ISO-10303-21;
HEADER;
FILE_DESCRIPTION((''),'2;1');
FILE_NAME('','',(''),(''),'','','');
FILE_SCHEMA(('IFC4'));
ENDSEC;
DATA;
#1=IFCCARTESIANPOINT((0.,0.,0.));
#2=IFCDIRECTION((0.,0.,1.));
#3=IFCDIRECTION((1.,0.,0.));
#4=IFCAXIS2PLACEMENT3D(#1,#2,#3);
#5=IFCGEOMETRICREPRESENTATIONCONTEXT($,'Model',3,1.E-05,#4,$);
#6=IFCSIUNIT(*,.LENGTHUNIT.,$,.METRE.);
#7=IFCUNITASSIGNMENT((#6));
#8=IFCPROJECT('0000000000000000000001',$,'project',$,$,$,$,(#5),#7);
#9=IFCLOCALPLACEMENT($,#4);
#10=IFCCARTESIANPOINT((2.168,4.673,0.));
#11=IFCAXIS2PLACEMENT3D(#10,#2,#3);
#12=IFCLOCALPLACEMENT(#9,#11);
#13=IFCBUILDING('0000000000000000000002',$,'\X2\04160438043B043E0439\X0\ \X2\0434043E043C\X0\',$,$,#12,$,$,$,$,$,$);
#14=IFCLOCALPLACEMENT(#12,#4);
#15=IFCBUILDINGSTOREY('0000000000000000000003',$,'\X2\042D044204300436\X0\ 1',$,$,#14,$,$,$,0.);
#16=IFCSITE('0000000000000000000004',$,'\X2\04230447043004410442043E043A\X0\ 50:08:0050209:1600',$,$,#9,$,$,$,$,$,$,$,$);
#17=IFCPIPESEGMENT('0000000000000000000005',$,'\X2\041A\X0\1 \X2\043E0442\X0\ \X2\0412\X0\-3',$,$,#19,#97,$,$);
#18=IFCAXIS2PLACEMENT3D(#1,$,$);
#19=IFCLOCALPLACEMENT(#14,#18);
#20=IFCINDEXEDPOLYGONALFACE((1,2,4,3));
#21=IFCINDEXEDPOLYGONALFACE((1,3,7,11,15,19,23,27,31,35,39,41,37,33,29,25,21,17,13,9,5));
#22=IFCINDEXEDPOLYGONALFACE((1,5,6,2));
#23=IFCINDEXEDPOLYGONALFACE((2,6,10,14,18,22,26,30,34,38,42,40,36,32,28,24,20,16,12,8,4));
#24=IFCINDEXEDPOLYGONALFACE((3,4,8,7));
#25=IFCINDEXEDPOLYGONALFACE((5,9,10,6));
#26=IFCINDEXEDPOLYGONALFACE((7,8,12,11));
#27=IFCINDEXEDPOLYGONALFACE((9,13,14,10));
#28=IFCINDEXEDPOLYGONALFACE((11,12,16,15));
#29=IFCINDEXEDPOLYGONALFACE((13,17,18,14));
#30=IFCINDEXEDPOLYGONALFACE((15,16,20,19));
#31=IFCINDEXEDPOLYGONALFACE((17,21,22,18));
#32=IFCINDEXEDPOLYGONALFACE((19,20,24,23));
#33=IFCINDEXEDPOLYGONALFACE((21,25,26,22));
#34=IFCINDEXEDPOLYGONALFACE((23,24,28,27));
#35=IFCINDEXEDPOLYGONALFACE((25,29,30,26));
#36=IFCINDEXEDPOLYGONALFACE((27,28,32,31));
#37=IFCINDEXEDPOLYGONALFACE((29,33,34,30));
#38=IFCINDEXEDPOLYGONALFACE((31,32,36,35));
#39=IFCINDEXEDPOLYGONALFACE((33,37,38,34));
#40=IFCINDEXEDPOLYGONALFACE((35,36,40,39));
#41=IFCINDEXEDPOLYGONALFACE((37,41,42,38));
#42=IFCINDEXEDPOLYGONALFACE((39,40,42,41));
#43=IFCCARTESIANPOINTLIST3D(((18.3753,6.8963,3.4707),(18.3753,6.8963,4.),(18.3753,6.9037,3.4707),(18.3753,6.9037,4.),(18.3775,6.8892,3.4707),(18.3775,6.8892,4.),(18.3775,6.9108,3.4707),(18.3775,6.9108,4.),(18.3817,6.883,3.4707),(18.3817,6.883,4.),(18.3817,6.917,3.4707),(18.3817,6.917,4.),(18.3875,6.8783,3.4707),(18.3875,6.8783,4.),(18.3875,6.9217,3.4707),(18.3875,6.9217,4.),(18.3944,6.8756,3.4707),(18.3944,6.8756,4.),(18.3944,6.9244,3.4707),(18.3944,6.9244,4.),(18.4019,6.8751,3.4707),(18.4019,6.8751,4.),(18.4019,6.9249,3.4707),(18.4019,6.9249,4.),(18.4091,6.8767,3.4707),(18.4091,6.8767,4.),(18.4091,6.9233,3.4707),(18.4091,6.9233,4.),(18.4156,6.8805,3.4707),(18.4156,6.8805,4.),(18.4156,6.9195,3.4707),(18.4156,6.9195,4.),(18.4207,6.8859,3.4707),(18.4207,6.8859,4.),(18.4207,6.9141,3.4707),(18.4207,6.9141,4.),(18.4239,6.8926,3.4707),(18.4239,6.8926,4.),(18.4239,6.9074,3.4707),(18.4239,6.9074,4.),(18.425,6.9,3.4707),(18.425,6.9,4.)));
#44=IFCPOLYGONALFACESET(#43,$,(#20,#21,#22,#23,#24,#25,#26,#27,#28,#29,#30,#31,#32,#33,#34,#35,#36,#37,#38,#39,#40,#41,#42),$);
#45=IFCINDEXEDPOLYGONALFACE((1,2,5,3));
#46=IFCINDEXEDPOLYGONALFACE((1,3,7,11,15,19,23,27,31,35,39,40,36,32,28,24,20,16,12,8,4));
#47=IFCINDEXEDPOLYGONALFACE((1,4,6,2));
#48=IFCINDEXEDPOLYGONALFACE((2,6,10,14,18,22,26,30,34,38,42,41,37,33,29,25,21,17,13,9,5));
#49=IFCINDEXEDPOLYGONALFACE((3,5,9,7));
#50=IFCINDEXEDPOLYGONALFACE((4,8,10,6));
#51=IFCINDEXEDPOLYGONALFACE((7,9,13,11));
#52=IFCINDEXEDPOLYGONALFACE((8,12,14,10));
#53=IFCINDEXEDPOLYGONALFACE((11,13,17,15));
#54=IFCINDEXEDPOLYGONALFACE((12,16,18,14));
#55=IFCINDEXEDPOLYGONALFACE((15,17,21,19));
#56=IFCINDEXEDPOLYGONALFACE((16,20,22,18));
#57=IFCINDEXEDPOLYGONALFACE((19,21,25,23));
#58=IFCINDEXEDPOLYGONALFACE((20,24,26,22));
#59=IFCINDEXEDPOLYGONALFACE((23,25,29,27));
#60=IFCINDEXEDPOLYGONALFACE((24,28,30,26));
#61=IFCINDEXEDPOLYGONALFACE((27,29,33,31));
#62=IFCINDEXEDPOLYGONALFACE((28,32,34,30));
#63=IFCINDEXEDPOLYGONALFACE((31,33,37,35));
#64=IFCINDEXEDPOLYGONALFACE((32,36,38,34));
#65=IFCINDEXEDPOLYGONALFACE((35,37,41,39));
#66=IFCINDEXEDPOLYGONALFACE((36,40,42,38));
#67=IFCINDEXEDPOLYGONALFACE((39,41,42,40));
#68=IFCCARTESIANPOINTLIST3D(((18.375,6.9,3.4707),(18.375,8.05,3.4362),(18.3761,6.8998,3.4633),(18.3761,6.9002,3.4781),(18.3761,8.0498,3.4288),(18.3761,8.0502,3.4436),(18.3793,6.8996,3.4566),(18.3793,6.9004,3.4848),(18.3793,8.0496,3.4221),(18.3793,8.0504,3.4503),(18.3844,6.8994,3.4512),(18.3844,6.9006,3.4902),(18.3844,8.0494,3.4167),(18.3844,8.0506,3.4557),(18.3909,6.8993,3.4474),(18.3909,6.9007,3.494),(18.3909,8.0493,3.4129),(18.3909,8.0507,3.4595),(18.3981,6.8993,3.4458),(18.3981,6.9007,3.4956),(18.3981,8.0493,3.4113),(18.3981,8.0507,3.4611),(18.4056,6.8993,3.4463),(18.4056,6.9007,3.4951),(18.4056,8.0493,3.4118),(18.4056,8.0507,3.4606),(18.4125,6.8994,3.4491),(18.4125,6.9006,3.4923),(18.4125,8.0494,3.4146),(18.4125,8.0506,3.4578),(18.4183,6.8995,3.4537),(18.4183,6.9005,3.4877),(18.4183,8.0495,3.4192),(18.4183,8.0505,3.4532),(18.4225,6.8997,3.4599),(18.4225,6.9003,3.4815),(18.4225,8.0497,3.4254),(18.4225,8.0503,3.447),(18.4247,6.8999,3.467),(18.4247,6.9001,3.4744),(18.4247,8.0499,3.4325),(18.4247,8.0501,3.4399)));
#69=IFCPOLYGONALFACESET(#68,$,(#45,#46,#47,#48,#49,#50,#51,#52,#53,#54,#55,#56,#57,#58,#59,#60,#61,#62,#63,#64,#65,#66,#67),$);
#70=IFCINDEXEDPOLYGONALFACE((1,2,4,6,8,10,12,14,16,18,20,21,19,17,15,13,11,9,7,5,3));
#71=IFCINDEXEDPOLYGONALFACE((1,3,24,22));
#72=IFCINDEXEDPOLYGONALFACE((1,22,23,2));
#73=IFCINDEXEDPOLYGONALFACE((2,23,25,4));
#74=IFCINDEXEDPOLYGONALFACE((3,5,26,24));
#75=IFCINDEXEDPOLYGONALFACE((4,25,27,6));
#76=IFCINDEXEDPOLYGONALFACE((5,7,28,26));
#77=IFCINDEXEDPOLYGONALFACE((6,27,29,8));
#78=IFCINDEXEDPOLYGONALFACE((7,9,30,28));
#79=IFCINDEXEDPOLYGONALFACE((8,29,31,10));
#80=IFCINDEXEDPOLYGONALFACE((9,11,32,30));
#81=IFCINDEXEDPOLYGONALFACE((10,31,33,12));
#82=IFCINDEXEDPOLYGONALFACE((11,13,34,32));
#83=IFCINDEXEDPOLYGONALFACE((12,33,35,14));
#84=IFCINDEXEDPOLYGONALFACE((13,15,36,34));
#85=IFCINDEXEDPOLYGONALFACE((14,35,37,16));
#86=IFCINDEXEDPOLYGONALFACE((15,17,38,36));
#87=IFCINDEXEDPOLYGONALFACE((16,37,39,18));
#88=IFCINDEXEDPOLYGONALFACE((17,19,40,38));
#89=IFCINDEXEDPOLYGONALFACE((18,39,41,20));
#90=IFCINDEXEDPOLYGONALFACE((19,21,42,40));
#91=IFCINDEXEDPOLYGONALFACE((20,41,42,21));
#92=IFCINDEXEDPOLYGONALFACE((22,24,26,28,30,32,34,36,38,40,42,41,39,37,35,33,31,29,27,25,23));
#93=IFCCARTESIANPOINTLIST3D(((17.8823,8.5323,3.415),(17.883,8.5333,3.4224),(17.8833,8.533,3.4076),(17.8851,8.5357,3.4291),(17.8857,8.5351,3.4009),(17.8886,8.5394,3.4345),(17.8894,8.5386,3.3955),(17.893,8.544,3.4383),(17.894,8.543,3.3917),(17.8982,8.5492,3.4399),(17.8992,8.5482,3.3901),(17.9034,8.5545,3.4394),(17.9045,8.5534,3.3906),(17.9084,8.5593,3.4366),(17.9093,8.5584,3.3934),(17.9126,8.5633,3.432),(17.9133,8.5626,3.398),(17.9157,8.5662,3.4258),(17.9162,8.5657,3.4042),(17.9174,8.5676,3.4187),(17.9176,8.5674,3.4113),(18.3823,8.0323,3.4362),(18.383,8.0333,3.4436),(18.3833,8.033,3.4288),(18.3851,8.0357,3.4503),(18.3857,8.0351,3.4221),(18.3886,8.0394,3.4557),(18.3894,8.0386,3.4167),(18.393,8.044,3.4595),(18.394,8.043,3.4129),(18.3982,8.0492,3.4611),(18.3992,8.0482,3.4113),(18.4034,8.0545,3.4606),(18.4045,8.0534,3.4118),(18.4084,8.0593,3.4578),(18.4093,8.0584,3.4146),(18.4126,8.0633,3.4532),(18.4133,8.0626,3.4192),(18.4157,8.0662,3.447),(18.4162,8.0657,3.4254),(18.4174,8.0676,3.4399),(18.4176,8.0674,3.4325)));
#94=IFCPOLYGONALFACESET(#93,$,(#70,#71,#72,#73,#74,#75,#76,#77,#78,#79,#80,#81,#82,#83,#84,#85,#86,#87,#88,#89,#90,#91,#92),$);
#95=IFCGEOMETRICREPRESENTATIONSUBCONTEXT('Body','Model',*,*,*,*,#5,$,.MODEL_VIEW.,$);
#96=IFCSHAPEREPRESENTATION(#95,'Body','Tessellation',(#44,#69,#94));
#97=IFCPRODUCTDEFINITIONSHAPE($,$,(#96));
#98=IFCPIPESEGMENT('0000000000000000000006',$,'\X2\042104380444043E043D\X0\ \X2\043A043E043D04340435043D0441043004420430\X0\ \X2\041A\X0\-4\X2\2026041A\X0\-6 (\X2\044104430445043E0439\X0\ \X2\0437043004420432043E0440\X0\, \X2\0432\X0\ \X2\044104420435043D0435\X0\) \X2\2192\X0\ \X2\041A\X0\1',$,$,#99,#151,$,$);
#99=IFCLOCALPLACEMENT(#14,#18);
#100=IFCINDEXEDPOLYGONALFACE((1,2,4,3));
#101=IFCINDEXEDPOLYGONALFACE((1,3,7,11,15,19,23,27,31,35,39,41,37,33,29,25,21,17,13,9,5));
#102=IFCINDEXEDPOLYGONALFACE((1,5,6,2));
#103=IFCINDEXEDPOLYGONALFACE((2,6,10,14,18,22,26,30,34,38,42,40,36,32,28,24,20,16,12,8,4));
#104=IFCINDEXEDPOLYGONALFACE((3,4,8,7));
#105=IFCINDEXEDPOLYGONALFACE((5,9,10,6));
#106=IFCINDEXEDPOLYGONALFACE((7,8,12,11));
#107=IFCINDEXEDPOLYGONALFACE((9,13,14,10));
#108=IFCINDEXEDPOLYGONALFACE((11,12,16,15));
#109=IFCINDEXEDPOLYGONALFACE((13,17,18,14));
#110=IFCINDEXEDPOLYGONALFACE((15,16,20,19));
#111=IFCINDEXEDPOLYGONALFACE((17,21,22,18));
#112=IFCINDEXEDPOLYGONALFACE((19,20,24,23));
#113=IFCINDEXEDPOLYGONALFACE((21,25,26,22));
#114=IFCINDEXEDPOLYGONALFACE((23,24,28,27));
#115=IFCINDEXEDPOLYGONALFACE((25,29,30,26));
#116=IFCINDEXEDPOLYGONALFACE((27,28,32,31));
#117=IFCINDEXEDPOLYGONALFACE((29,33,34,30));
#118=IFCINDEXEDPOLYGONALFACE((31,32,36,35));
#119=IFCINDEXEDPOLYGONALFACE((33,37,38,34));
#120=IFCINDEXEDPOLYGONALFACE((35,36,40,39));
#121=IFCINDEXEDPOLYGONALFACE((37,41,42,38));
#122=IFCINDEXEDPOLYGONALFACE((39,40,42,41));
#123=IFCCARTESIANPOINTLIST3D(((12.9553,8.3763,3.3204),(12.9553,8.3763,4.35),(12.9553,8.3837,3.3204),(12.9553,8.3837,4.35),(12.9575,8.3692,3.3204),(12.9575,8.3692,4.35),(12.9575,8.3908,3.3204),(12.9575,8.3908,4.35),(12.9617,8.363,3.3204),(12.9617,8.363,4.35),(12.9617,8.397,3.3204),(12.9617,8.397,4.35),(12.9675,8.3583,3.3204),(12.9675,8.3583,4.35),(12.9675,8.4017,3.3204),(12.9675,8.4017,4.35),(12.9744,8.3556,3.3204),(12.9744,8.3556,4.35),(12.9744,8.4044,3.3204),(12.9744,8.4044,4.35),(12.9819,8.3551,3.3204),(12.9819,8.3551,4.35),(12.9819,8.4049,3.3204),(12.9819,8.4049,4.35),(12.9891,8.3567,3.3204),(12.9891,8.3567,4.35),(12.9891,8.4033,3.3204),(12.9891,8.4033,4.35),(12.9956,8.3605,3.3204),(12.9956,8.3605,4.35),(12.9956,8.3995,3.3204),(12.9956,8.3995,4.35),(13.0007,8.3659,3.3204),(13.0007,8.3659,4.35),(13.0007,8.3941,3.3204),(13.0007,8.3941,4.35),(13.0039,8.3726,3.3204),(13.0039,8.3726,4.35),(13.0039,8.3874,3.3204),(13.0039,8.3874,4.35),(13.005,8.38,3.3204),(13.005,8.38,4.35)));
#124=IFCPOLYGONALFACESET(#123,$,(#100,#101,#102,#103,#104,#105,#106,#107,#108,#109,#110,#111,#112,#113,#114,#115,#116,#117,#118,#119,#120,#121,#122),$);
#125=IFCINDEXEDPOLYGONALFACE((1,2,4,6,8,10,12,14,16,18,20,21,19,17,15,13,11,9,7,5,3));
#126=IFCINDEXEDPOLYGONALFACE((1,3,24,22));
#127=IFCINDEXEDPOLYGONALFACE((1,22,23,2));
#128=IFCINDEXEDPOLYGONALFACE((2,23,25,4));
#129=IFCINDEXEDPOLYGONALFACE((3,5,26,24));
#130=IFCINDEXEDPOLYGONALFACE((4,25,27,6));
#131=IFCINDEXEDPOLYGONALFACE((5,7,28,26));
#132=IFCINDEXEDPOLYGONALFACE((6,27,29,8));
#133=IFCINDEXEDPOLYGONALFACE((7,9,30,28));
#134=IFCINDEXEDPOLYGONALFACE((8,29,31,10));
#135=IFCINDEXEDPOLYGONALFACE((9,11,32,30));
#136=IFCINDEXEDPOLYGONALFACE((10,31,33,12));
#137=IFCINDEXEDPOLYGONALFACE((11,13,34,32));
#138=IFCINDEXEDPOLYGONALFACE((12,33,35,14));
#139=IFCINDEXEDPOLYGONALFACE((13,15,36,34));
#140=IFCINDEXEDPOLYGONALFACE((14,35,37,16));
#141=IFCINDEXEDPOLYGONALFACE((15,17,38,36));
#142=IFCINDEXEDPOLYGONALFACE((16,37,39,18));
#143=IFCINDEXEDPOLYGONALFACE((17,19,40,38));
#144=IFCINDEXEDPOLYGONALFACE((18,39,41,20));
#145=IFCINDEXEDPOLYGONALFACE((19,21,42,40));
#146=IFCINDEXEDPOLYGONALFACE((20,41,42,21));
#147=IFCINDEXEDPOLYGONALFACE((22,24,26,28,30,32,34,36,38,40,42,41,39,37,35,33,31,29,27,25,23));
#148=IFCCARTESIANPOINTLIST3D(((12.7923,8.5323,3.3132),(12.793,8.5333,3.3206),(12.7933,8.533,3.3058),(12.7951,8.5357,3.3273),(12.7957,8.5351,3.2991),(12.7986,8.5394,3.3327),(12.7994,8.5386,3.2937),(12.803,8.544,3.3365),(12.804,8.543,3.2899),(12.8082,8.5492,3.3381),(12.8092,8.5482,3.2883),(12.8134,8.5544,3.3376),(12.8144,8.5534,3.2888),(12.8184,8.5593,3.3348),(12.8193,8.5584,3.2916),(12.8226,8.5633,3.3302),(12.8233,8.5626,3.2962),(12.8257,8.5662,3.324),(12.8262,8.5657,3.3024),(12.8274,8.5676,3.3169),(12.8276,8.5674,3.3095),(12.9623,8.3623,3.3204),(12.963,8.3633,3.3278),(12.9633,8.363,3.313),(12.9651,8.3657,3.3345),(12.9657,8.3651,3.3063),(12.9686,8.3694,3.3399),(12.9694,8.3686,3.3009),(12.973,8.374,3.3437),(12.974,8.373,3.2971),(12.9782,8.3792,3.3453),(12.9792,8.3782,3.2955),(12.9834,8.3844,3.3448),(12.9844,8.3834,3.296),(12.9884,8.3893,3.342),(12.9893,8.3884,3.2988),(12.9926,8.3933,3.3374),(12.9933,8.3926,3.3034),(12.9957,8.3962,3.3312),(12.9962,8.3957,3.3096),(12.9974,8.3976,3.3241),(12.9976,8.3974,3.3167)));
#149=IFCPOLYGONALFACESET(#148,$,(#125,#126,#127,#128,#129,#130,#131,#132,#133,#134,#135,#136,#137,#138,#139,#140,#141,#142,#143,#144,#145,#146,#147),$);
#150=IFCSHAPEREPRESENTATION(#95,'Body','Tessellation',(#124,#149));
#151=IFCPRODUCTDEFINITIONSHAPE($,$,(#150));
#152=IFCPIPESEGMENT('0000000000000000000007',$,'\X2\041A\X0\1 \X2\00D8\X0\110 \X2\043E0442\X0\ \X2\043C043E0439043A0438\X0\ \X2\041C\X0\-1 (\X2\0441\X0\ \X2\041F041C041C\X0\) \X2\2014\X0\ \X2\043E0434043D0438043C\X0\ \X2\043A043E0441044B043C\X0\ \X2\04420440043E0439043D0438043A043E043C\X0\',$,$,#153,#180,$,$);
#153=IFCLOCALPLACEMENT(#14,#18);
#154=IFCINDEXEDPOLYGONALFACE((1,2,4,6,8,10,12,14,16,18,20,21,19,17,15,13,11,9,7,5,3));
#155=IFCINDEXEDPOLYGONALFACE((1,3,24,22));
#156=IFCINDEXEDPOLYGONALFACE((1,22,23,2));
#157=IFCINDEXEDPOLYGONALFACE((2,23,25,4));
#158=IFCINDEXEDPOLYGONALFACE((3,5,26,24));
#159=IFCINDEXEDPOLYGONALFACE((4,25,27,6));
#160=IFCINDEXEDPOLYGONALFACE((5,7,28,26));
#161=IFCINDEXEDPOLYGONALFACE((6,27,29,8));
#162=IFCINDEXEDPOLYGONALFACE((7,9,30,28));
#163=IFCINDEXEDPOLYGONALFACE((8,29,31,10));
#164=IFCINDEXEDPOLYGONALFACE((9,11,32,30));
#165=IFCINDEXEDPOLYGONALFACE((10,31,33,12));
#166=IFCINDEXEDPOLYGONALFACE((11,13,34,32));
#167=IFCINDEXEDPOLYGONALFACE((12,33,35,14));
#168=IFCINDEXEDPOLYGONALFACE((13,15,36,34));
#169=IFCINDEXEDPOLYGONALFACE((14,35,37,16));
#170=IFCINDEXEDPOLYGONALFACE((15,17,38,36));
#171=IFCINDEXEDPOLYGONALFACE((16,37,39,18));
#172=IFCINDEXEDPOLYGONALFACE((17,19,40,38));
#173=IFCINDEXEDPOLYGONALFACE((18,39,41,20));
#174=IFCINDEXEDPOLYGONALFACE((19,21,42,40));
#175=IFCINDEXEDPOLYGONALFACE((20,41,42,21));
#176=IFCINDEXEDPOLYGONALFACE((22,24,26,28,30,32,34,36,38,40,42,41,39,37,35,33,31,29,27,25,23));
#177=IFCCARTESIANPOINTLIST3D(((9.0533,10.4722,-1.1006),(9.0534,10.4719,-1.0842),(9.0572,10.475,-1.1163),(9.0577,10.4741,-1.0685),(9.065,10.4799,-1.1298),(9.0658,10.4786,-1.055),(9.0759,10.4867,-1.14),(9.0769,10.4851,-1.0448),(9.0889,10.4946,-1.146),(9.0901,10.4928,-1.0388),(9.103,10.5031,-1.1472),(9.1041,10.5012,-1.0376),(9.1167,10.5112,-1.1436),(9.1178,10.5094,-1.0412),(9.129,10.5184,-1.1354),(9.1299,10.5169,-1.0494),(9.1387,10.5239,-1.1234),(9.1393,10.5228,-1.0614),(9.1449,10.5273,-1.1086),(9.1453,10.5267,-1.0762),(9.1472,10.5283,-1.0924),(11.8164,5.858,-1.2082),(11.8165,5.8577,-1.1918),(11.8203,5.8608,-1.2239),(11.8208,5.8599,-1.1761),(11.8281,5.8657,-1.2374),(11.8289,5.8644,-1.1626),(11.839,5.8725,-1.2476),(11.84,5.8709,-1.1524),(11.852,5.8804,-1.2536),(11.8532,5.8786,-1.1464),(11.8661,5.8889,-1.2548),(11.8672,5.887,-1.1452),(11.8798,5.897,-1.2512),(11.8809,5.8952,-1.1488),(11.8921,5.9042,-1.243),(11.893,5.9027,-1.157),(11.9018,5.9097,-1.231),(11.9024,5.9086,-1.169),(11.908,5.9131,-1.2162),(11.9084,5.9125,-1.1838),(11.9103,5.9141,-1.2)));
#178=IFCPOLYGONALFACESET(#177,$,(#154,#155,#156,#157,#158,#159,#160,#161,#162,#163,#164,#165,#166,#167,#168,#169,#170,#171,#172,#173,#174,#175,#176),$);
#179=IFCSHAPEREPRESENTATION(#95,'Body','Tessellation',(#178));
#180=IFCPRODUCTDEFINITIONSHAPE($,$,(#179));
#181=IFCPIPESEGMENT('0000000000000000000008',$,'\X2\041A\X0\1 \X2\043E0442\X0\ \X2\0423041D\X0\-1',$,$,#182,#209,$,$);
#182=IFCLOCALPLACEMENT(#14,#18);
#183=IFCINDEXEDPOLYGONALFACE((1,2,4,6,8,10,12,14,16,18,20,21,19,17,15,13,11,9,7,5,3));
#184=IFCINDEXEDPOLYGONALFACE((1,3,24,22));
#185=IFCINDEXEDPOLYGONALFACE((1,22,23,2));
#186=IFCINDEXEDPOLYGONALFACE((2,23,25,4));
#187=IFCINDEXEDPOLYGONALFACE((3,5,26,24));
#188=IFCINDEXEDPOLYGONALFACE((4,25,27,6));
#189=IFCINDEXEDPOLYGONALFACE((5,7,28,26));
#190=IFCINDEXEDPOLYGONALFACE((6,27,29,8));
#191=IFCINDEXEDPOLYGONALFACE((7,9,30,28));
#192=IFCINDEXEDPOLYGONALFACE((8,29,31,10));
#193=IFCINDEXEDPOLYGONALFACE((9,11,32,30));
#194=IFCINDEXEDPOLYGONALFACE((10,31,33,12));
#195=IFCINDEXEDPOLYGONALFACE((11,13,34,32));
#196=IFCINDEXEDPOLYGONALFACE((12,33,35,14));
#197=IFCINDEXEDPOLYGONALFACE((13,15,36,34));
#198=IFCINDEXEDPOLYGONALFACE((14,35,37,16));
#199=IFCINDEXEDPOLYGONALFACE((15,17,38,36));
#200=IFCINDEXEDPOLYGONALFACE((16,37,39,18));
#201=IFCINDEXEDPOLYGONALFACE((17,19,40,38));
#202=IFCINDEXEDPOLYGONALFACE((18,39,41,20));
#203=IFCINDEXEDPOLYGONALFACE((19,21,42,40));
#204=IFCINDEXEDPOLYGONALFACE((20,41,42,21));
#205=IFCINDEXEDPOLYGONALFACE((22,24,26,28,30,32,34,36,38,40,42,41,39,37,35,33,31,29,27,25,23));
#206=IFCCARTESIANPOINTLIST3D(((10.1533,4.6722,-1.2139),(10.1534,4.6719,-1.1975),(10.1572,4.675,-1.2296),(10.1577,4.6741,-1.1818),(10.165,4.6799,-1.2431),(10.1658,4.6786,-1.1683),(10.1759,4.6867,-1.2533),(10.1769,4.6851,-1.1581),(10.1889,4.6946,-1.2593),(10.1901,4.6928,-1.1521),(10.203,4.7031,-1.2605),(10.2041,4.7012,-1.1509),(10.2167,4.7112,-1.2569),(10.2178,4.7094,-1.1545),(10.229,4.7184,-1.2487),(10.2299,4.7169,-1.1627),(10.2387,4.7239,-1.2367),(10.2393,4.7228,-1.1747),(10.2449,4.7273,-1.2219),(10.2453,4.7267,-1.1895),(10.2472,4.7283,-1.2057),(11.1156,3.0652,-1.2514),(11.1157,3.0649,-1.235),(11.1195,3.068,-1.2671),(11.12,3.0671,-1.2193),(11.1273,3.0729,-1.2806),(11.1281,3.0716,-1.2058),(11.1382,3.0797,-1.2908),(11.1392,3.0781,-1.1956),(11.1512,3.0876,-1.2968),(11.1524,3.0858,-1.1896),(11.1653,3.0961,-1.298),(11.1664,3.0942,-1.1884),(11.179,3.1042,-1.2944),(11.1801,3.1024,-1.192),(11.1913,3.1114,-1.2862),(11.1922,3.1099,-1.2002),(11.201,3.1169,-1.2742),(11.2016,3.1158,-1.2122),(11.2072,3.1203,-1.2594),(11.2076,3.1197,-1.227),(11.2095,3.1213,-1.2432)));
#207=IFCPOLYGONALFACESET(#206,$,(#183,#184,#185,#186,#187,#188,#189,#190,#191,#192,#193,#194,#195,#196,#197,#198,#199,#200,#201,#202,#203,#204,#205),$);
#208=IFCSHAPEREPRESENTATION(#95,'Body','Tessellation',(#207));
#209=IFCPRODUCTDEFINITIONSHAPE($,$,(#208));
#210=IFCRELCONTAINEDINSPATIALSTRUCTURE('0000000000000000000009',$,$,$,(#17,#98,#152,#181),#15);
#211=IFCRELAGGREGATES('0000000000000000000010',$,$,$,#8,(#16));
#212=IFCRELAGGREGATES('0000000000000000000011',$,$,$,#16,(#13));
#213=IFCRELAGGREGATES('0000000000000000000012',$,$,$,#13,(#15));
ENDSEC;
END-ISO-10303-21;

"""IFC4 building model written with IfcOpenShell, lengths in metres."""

from ifc_helpers import new_model, si_unit, frame, origin_with_axes, origin_2d, place, context, subcontext, project, spatial, circle, extrude, element, save


model = new_model("IFC4")

# Units and contexts
model_context = context("Model", 3, precision=1e-05, world=origin_with_axes())
body_context = subcontext(model_context, "Body", "Model", "MODEL_VIEW")
ifc_project = project(units=[si_unit("LENGTHUNIT", "METRE")], contexts=[model_context])

# Site, building, storey
site_placement = place(None, origin_with_axes())
site = spatial("IfcSite", under=ifc_project, at=site_placement, Name="Участок 50:08:0050209:1600")
building_placement = place(site_placement, frame((2.168, 4.673, 0.0), z_axis=(0.0, 0.0, 1.0), x_axis=(1.0, 0.0, 0.0)))
building = spatial("IfcBuilding", under=site, at=building_placement, Name="Жилой дом")
storey_placement = place(building_placement, origin_with_axes())
storey = spatial("IfcBuildingStorey", under=building, at=storey_placement, Name="Этаж 1", Elevation=0.0)

# Pipe segments
pipe_segment_1_placement = place(storey_placement, origin_with_axes())
element("IfcPipeSegment", 1, at=pipe_segment_1_placement, inside=storey, Name="К1 от В-3", context=body_context, shape_type="SweptSolid", body=[
    extrude(circle(Radius=0.025, at=origin_2d()), frame((18.4, 6.9, 4.0), z_axis=(0.0, 0.0, -1.0), x_axis=(1.0, 0.0, 0.0)), (0.0, 0.0, 1.0), 0.5293),
    extrude(circle(Radius=0.025, at=origin_2d()), frame((18.4, 6.9, 3.4707), z_axis=(0.0, 0.99955, -0.029987), x_axis=(-1.0, 0.0, 0.0)), (0.0, 0.0, 1.0), 1.1505),
    extrude(circle(Radius=0.025, at=origin_2d()), frame((18.4, 8.05, 3.4362), z_axis=(-0.706789, 0.706789, -0.029968), x_axis=(-0.707107, -0.707107, 0.0)), (0.0, 0.0, 1.0), 0.7074),
])
pipe_segment_2_placement = place(storey_placement, origin_with_axes())
element("IfcPipeSegment", 2, at=pipe_segment_2_placement, inside=storey, Name="Сифон конденсата К-4…К-6 (сухой затвор, в стене) → К1", context=body_context, shape_type="SweptSolid", body=[
    extrude(circle(Radius=0.025, at=origin_2d()), frame((12.98, 8.38, 4.35), z_axis=(0.0, 0.0, -1.0), x_axis=(1.0, 0.0, 0.0)), (0.0, 0.0, 1.0), 1.0296),
    extrude(circle(Radius=0.025, at=origin_2d()), frame((12.98, 8.38, 3.3204), z_axis=(-0.70679, 0.70679, -0.029935), x_axis=(-0.707107, -0.707107, 0.0)), (0.0, 0.0, 1.0), 0.2405),
])
pipe_segment_3_placement = place(storey_placement, origin_with_axes())
element("IfcPipeSegment", 3, at=pipe_segment_3_placement, inside=storey, Name="К1 Ø110 от мойки М-1 (с ПММ) — одним косым тройником", context=body_context, shape_type="SweptSolid", body=[
    extrude(circle(Radius=0.055, at=origin_2d()), frame((9.1, 10.5, -1.0924), z_axis=(0.513652, -0.857766, -0.020003), x_axis=(0.857937, 0.513755, 0.0)), (0.0, 0.0, 1.0), 5.3793),
])
pipe_segment_4_placement = place(storey_placement, origin_with_axes())
element("IfcPipeSegment", 4, at=pipe_segment_4_placement, inside=storey, Name="К1 от УН-1", context=body_context, shape_type="SweptSolid", body=[
    extrude(circle(Radius=0.055, at=origin_2d()), frame((10.2, 4.7, -1.2057), z_axis=(0.513647, -0.857768, -0.020016), x_axis=(0.85794, 0.51375, 0.0)), (0.0, 0.0, 1.0), 1.8735),
])

save(model, "model.ifc")
